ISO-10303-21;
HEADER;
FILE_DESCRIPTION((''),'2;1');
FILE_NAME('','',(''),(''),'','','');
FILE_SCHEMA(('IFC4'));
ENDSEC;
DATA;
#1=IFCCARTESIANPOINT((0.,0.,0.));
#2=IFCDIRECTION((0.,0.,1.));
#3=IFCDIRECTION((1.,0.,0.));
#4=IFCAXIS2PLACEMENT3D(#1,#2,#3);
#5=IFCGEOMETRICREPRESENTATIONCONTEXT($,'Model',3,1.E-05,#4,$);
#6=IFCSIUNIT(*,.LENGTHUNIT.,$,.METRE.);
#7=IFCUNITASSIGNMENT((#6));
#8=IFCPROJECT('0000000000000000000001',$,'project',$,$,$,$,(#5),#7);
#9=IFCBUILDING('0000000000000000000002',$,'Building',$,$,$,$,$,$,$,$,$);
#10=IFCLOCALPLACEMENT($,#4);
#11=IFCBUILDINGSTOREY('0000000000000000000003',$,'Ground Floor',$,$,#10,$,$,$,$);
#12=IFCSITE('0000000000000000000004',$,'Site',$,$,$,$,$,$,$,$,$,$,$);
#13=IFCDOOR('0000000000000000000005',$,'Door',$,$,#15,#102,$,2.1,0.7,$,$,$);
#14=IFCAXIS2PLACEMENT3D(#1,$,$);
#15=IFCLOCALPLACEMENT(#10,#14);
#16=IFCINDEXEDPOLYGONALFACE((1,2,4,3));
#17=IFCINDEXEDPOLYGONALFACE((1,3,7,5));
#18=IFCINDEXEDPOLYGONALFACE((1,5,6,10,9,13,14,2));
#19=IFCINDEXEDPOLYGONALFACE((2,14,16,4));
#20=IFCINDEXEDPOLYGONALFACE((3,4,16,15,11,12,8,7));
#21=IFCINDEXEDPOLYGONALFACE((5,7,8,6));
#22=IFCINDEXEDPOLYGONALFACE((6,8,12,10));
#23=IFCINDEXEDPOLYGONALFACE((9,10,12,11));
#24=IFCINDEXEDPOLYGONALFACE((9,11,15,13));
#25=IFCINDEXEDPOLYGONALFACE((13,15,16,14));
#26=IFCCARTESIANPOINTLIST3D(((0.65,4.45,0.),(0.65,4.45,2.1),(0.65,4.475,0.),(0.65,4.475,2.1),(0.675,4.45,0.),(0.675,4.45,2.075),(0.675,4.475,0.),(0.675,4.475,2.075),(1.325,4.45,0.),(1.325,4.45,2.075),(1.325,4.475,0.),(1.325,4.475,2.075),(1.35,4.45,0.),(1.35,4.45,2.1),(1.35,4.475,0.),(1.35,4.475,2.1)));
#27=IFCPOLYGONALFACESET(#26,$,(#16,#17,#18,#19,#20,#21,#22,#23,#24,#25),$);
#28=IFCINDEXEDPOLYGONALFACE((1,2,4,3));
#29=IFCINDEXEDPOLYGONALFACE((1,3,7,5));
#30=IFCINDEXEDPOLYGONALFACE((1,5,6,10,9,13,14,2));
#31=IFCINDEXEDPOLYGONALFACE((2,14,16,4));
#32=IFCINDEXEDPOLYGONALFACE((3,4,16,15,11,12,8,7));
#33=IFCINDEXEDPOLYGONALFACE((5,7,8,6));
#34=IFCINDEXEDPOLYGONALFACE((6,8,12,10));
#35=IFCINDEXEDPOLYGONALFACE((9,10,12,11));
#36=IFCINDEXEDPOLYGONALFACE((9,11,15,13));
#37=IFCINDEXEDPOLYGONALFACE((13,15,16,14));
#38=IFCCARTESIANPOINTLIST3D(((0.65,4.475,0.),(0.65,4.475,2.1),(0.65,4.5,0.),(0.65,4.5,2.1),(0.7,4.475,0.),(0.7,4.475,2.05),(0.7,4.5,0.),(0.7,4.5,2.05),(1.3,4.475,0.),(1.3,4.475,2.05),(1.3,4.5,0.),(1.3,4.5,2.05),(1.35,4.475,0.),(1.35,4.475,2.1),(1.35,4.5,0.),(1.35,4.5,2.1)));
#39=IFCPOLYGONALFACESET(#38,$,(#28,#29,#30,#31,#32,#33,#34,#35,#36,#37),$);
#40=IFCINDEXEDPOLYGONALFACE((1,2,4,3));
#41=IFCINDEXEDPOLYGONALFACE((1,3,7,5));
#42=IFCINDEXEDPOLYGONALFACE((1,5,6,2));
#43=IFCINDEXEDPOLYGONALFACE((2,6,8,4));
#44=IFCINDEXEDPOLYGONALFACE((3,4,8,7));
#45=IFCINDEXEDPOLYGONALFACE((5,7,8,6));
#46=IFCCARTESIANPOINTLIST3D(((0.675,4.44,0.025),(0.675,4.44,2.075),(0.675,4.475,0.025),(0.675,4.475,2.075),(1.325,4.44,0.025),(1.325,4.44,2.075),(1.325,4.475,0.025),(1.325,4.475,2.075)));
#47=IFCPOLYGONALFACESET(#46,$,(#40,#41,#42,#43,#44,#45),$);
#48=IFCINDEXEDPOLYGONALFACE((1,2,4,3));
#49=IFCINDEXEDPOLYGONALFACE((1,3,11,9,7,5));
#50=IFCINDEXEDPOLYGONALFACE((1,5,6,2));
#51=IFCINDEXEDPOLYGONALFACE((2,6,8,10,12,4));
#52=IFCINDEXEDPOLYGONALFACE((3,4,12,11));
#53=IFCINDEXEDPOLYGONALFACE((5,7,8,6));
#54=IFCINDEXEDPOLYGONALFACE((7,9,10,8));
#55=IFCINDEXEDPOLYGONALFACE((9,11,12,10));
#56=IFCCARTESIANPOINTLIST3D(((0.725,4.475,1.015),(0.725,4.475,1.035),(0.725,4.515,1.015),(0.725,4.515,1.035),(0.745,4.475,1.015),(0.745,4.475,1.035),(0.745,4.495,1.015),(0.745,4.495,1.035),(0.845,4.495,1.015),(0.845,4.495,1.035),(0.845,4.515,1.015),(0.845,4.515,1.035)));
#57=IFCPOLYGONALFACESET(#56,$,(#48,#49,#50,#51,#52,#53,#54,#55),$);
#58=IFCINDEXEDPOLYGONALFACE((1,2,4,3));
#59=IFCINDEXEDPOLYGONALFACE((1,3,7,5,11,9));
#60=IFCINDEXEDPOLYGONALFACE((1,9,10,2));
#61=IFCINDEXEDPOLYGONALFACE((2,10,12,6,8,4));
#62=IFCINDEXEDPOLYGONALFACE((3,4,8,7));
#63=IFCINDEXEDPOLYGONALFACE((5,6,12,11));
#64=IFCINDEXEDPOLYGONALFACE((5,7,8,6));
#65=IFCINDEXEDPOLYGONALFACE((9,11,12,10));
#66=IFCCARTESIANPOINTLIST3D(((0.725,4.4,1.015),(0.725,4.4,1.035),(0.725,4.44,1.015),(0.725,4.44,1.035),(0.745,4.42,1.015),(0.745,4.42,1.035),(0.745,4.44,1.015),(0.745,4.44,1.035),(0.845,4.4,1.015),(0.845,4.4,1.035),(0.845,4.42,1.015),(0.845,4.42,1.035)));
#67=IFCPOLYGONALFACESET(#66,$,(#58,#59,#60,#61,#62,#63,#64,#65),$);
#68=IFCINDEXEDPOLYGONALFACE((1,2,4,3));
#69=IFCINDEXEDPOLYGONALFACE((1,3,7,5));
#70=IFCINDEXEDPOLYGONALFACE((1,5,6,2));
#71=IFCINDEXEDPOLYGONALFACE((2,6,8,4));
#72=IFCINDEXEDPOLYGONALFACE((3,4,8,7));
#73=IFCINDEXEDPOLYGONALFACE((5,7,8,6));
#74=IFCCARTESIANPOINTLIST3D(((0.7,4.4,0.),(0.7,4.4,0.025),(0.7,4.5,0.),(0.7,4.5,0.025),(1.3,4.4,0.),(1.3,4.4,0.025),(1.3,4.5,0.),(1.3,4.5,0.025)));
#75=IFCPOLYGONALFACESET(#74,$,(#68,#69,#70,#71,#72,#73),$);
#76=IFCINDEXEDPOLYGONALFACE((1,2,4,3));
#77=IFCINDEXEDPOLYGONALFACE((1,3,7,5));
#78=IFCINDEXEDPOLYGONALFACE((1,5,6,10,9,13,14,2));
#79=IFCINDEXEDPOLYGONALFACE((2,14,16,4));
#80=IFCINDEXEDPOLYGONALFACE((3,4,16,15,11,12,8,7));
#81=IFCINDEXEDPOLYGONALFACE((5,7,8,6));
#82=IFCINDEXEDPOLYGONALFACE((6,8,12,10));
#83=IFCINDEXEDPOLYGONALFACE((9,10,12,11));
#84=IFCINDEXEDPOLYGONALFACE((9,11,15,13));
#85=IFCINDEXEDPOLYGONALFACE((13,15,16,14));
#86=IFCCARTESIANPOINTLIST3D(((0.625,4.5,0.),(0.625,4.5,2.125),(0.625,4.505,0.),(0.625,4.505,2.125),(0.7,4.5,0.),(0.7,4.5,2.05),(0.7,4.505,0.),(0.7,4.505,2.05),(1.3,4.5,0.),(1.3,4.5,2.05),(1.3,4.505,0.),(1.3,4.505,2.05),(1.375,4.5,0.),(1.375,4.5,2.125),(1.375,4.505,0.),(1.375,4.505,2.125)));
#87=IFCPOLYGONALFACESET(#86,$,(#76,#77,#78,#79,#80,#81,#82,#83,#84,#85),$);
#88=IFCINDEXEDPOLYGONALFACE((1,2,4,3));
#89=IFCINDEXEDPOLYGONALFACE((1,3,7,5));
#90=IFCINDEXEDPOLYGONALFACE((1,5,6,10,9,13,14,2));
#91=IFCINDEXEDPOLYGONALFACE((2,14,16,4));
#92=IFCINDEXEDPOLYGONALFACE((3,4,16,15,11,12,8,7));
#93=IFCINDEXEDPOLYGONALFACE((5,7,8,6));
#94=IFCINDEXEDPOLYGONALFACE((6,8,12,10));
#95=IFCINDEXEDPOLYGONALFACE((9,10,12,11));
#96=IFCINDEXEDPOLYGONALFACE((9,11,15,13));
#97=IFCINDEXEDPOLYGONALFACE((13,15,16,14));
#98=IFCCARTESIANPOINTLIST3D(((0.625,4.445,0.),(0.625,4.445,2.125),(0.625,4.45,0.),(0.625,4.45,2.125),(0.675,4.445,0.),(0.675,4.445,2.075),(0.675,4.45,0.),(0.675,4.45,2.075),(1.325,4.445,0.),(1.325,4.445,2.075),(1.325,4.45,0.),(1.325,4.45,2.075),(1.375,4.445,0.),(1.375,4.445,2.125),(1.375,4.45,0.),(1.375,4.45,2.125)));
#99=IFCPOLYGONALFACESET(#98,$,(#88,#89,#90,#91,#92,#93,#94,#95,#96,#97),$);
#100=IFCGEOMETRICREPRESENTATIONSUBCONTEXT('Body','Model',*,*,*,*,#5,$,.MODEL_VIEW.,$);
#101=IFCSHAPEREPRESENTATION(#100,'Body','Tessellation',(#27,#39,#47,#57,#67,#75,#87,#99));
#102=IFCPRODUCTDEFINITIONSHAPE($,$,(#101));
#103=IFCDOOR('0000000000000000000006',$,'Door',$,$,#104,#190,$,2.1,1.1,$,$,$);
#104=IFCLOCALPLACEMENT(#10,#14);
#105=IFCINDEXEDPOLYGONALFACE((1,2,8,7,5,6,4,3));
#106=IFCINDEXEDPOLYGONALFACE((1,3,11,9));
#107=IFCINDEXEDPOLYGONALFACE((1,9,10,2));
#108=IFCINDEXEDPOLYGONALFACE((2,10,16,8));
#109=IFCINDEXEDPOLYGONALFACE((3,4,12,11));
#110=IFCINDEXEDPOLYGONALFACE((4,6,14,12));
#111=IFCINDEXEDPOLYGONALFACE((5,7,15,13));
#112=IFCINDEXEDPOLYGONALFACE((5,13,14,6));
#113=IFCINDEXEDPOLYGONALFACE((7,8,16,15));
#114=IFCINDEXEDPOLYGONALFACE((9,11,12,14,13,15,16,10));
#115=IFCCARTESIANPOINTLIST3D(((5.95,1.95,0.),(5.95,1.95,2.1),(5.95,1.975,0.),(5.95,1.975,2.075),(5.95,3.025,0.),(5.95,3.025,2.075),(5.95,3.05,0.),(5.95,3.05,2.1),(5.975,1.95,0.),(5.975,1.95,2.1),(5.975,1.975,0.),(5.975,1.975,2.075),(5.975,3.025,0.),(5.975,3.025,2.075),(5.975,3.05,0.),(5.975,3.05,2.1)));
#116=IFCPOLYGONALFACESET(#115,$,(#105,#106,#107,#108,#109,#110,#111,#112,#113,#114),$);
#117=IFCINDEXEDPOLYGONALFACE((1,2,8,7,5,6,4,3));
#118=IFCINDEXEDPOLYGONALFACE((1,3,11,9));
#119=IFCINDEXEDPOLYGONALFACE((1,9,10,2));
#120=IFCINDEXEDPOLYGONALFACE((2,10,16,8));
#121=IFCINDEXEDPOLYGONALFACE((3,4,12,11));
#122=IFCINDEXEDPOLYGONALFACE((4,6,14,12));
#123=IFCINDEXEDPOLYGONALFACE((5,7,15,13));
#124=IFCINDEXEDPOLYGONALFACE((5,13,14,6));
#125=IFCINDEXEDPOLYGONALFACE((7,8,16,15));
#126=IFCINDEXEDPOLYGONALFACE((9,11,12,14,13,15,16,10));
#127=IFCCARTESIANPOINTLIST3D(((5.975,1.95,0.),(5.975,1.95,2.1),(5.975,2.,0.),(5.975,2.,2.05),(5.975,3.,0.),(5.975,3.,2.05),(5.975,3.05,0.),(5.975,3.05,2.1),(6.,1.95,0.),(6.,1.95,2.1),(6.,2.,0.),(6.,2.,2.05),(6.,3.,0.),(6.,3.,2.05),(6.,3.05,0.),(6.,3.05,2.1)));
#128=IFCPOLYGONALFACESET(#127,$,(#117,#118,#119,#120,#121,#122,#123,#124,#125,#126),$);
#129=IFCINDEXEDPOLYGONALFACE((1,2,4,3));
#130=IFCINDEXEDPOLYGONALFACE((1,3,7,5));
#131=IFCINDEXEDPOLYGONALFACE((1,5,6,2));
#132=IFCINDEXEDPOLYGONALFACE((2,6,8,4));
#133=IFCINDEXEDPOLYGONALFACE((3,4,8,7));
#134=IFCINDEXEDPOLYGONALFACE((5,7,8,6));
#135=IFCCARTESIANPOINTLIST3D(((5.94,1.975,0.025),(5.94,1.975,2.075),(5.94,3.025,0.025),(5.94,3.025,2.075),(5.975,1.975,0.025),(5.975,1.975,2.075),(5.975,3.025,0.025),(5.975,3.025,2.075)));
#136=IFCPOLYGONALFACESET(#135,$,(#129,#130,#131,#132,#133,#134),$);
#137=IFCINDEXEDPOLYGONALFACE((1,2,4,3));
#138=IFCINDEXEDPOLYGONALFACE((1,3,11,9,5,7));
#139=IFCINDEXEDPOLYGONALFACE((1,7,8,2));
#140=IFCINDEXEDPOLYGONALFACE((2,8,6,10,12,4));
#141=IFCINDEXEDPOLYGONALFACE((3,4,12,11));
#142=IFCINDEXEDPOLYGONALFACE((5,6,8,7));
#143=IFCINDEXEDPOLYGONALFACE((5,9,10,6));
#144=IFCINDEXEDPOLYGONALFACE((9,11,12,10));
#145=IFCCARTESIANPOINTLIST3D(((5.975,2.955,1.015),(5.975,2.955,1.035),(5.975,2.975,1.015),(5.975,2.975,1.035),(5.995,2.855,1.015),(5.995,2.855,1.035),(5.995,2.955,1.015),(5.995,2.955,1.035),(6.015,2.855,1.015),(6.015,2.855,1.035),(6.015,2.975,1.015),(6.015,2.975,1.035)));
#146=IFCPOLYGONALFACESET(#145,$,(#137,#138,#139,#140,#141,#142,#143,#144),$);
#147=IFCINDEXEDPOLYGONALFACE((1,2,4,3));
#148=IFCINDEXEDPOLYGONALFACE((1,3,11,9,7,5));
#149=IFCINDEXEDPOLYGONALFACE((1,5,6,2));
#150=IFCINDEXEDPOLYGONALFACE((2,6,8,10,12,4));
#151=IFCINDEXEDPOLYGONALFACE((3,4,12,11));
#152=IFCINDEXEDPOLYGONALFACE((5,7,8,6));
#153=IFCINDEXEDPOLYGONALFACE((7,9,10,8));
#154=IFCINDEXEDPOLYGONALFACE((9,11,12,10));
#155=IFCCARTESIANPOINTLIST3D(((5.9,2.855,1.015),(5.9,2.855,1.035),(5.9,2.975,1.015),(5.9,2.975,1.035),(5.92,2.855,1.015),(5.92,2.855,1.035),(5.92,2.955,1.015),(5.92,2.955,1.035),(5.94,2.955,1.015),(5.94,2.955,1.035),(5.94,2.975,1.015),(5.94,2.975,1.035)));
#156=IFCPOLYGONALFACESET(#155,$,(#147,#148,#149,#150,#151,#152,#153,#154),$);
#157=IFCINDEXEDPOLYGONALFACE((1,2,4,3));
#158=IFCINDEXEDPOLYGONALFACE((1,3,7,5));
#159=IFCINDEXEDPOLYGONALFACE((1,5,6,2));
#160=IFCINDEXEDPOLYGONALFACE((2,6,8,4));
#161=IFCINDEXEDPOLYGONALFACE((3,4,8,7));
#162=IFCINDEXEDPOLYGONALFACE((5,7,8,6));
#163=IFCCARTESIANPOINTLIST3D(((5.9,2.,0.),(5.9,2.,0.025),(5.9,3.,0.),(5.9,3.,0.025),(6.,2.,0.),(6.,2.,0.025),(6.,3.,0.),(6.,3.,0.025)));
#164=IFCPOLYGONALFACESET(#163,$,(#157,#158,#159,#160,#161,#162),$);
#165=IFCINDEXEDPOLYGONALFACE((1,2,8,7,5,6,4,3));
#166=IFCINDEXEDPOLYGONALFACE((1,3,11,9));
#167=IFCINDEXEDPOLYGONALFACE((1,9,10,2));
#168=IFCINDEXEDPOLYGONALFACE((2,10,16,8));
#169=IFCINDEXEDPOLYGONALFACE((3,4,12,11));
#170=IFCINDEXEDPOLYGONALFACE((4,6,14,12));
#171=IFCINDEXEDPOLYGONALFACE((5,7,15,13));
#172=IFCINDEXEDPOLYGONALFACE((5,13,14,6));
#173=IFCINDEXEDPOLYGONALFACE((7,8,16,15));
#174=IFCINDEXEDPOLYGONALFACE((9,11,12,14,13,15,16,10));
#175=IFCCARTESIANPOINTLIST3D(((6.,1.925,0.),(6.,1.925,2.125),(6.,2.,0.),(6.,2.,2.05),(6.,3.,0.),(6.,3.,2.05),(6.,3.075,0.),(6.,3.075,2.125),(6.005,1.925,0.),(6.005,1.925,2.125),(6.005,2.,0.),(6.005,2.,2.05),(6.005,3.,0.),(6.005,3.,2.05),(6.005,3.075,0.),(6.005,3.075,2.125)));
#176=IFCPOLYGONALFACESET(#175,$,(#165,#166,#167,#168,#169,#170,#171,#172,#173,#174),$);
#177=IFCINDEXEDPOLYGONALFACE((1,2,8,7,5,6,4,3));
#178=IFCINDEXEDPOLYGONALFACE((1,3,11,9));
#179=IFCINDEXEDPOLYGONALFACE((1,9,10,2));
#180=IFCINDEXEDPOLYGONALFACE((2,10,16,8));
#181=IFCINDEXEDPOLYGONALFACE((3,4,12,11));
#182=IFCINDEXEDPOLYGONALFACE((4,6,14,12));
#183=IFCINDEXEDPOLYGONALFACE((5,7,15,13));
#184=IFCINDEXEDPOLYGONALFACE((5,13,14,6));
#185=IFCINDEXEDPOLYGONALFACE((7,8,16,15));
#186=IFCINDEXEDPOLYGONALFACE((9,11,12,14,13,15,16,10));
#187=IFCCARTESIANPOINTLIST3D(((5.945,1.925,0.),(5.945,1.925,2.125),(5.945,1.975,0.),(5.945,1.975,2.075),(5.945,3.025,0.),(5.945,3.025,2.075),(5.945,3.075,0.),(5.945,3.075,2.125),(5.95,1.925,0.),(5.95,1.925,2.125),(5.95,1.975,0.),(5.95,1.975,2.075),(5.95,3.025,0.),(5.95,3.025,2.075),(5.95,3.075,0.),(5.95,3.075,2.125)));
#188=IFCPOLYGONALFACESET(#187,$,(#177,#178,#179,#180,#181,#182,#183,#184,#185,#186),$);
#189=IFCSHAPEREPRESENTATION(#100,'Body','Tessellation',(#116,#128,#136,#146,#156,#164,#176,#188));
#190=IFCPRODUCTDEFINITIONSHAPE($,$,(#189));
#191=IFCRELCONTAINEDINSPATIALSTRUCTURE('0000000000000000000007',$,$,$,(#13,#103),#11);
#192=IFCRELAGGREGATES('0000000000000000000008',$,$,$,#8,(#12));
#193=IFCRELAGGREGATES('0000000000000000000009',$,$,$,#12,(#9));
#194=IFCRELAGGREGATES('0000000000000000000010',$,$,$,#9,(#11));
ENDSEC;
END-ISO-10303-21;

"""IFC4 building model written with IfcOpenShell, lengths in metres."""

from ifc_helpers import new_model, si_unit, frame, origin_with_axes, place, context, subcontext, project, spatial, line, indexed_curve, outline, extrude, element, save


model = new_model("IFC4")

# Units and contexts
model_context = context("Model", 3, precision=1e-05, world=origin_with_axes())
body_context = subcontext(model_context, "Body", "Model", "MODEL_VIEW")
ifc_project = project(units=[si_unit("LENGTHUNIT", "METRE")], contexts=[model_context])

# Site, building, storey
site = spatial("IfcSite", under=ifc_project, Name="Site")
building = spatial("IfcBuilding", under=site, Name="Building")
storey_placement = place(None, origin_with_axes())
storey = spatial("IfcBuildingStorey", under=building, at=storey_placement, Name="Ground Floor")

# Doors
door_1_placement = place(storey_placement, frame((1.35, 4.5, 0.0), z_axis=(0.0, 0.0, 1.0), x_axis=(-1.0, 0.0, 0.0)))
element("IfcDoor", 1, at=door_1_placement, inside=storey, Name="Door", OverallHeight=2.1, OverallWidth=0.7, context=body_context, shape_type="SweptSolid", body=[
    extrude(outline(indexed_curve([(0.0, 0.0), (0.0, 2.1), (0.7, 2.1), (0.7, 0.0), (0.675, 0.0), (0.675, 2.075), (0.025, 2.075), (0.025, 0.0)], segments=[line(1, 2, 3, 4, 5, 6, 7, 8, 1)])), frame((0.0, 0.025, 0.0), z_axis=(0.0, -1.0, 0.0), x_axis=(1.0, 0.0, 0.0)), (0.0, 0.0, -1.0), 0.025),
    extrude(outline(indexed_curve([(0.0, 0.0), (0.0, 2.1), (0.7, 2.1), (0.7, 0.0), (0.65, 0.0), (0.65, 2.05), (0.05, 2.05), (0.05, 0.0)], segments=[line(1, 2, 3, 4, 5, 6, 7, 8, 1)])), frame((0.0, 0.0, 0.0), z_axis=(0.0, -1.0, 0.0), x_axis=(1.0, 0.0, 0.0)), (0.0, 0.0, -1.0), 0.025),
    extrude(outline(indexed_curve([(0.0, 0.0), (0.65, 0.0), (0.65, 0.035), (0.0, 0.035)], segments=[line(1, 2, 3, 4, 1)])), frame((0.025, 0.025, 0.025), z_axis=(0.0, 0.0, 1.0), x_axis=(1.0, 0.0, 0.0)), (0.0, 0.0, 1.0), 2.05),
    extrude(outline(indexed_curve([(0.0, 0.0), (0.0, -0.04), (-0.12, -0.04), (-0.12, -0.02), (-0.02, -0.02), (-0.02, 0.0)], segments=[line(1, 2, 3, 4, 5, 6, 1)])), frame((0.625, 0.025, 1.015), z_axis=(0.0, 0.0, 1.0), x_axis=(1.0, 0.0, 0.0)), (0.0, 0.0, 1.0), 0.02),
    extrude(outline(indexed_curve([(0.0, 0.0), (0.0, 0.04), (-0.12, 0.04), (-0.12, 0.02), (-0.02, 0.02), (-0.02, 0.0)], segments=[line(1, 2, 3, 4, 5, 6, 1)])), frame((0.625, 0.06, 1.015), z_axis=(0.0, 0.0, 1.0), x_axis=(1.0, 0.0, 0.0)), (0.0, 0.0, 1.0), 0.02),
    extrude(outline(indexed_curve([(0.0, 0.0), (0.6, 0.0), (0.6, 0.1), (0.0, 0.1)], segments=[line(1, 2, 3, 4, 1)])), frame((0.05, 0.0, 0.0), z_axis=(0.0, 0.0, 1.0), x_axis=(1.0, 0.0, 0.0)), (0.0, 0.0, 1.0), 0.025),
    extrude(outline(indexed_curve([(0.0, 0.0), (0.0, 2.125), (0.75, 2.125), (0.75, 0.0), (0.675, 0.0), (0.675, 2.05), (0.075, 2.05), (0.075, 0.0)], segments=[line(1, 2, 3, 4, 5, 6, 7, 8, 1)])), frame((-0.025, -0.005, 0.0), z_axis=(0.0, -1.0, 0.0), x_axis=(1.0, 0.0, 0.0)), (0.0, 0.0, -1.0), 0.005),
    extrude(outline(indexed_curve([(0.0, 0.0), (0.0, 2.125), (0.75, 2.125), (0.75, 0.0), (0.7, 0.0), (0.7, 2.075), (0.05, 2.075), (0.05, 0.0)], segments=[line(1, 2, 3, 4, 5, 6, 7, 8, 1)])), frame((-0.025, 0.05, 0.0), z_axis=(0.0, -1.0, 0.0), x_axis=(1.0, 0.0, 0.0)), (0.0, 0.0, -1.0), 0.005),
])
door_2_placement = place(storey_placement, frame((6.0, 1.95, 0.0), z_axis=(0.0, 0.0, 1.0), x_axis=(0.0, 1.0, 0.0)))
element("IfcDoor", 2, at=door_2_placement, inside=storey, Name="Door", OverallHeight=2.1, OverallWidth=1.1, context=body_context, shape_type="SweptSolid", body=[
    extrude(outline(indexed_curve([(0.0, 0.0), (0.0, 2.1), (1.1, 2.1), (1.1, 0.0), (1.075, 0.0), (1.075, 2.075), (0.025, 2.075), (0.025, 0.0)], segments=[line(1, 2, 3, 4, 5, 6, 7, 8, 1)])), frame((0.0, 0.025, 0.0), z_axis=(0.0, -1.0, 0.0), x_axis=(1.0, 0.0, 0.0)), (0.0, 0.0, -1.0), 0.025),
    extrude(outline(indexed_curve([(0.0, 0.0), (0.0, 2.1), (1.1, 2.1), (1.1, 0.0), (1.05, 0.0), (1.05, 2.05), (0.05, 2.05), (0.05, 0.0)], segments=[line(1, 2, 3, 4, 5, 6, 7, 8, 1)])), frame((0.0, 0.0, 0.0), z_axis=(0.0, -1.0, 0.0), x_axis=(1.0, 0.0, 0.0)), (0.0, 0.0, -1.0), 0.025),
    extrude(outline(indexed_curve([(0.0, 0.0), (1.05, 0.0), (1.05, 0.035), (0.0, 0.035)], segments=[line(1, 2, 3, 4, 1)])), frame((0.025, 0.025, 0.025), z_axis=(0.0, 0.0, 1.0), x_axis=(1.0, 0.0, 0.0)), (0.0, 0.0, 1.0), 2.05),
    extrude(outline(indexed_curve([(0.0, 0.0), (0.0, -0.04), (-0.12, -0.04), (-0.12, -0.02), (-0.02, -0.02), (-0.02, 0.0)], segments=[line(1, 2, 3, 4, 5, 6, 1)])), frame((1.025, 0.025, 1.015), z_axis=(0.0, 0.0, 1.0), x_axis=(1.0, 0.0, 0.0)), (0.0, 0.0, 1.0), 0.02),
    extrude(outline(indexed_curve([(0.0, 0.0), (0.0, 0.04), (-0.12, 0.04), (-0.12, 0.02), (-0.02, 0.02), (-0.02, 0.0)], segments=[line(1, 2, 3, 4, 5, 6, 1)])), frame((1.025, 0.06, 1.015), z_axis=(0.0, 0.0, 1.0), x_axis=(1.0, 0.0, 0.0)), (0.0, 0.0, 1.0), 0.02),
    extrude(outline(indexed_curve([(0.0, 0.0), (1.0, 0.0), (1.0, 0.1), (0.0, 0.1)], segments=[line(1, 2, 3, 4, 1)])), frame((0.05, 0.0, 0.0), z_axis=(0.0, 0.0, 1.0), x_axis=(1.0, 0.0, 0.0)), (0.0, 0.0, 1.0), 0.025),
    extrude(outline(indexed_curve([(0.0, 0.0), (0.0, 2.125), (1.15, 2.125), (1.15, 0.0), (1.075, 0.0), (1.075, 2.05), (0.075, 2.05), (0.075, 0.0)], segments=[line(1, 2, 3, 4, 5, 6, 7, 8, 1)])), frame((-0.025, -0.005, 0.0), z_axis=(0.0, -1.0, 0.0), x_axis=(1.0, 0.0, 0.0)), (0.0, 0.0, -1.0), 0.005),
    extrude(outline(indexed_curve([(0.0, 0.0), (0.0, 2.125), (1.15, 2.125), (1.15, 0.0), (1.1, 0.0), (1.1, 2.075), (0.05, 2.075), (0.05, 0.0)], segments=[line(1, 2, 3, 4, 5, 6, 7, 8, 1)])), frame((-0.025, 0.05, 0.0), z_axis=(0.0, -1.0, 0.0), x_axis=(1.0, 0.0, 0.0)), (0.0, 0.0, -1.0), 0.005),
])

save(model, "model.ifc")
